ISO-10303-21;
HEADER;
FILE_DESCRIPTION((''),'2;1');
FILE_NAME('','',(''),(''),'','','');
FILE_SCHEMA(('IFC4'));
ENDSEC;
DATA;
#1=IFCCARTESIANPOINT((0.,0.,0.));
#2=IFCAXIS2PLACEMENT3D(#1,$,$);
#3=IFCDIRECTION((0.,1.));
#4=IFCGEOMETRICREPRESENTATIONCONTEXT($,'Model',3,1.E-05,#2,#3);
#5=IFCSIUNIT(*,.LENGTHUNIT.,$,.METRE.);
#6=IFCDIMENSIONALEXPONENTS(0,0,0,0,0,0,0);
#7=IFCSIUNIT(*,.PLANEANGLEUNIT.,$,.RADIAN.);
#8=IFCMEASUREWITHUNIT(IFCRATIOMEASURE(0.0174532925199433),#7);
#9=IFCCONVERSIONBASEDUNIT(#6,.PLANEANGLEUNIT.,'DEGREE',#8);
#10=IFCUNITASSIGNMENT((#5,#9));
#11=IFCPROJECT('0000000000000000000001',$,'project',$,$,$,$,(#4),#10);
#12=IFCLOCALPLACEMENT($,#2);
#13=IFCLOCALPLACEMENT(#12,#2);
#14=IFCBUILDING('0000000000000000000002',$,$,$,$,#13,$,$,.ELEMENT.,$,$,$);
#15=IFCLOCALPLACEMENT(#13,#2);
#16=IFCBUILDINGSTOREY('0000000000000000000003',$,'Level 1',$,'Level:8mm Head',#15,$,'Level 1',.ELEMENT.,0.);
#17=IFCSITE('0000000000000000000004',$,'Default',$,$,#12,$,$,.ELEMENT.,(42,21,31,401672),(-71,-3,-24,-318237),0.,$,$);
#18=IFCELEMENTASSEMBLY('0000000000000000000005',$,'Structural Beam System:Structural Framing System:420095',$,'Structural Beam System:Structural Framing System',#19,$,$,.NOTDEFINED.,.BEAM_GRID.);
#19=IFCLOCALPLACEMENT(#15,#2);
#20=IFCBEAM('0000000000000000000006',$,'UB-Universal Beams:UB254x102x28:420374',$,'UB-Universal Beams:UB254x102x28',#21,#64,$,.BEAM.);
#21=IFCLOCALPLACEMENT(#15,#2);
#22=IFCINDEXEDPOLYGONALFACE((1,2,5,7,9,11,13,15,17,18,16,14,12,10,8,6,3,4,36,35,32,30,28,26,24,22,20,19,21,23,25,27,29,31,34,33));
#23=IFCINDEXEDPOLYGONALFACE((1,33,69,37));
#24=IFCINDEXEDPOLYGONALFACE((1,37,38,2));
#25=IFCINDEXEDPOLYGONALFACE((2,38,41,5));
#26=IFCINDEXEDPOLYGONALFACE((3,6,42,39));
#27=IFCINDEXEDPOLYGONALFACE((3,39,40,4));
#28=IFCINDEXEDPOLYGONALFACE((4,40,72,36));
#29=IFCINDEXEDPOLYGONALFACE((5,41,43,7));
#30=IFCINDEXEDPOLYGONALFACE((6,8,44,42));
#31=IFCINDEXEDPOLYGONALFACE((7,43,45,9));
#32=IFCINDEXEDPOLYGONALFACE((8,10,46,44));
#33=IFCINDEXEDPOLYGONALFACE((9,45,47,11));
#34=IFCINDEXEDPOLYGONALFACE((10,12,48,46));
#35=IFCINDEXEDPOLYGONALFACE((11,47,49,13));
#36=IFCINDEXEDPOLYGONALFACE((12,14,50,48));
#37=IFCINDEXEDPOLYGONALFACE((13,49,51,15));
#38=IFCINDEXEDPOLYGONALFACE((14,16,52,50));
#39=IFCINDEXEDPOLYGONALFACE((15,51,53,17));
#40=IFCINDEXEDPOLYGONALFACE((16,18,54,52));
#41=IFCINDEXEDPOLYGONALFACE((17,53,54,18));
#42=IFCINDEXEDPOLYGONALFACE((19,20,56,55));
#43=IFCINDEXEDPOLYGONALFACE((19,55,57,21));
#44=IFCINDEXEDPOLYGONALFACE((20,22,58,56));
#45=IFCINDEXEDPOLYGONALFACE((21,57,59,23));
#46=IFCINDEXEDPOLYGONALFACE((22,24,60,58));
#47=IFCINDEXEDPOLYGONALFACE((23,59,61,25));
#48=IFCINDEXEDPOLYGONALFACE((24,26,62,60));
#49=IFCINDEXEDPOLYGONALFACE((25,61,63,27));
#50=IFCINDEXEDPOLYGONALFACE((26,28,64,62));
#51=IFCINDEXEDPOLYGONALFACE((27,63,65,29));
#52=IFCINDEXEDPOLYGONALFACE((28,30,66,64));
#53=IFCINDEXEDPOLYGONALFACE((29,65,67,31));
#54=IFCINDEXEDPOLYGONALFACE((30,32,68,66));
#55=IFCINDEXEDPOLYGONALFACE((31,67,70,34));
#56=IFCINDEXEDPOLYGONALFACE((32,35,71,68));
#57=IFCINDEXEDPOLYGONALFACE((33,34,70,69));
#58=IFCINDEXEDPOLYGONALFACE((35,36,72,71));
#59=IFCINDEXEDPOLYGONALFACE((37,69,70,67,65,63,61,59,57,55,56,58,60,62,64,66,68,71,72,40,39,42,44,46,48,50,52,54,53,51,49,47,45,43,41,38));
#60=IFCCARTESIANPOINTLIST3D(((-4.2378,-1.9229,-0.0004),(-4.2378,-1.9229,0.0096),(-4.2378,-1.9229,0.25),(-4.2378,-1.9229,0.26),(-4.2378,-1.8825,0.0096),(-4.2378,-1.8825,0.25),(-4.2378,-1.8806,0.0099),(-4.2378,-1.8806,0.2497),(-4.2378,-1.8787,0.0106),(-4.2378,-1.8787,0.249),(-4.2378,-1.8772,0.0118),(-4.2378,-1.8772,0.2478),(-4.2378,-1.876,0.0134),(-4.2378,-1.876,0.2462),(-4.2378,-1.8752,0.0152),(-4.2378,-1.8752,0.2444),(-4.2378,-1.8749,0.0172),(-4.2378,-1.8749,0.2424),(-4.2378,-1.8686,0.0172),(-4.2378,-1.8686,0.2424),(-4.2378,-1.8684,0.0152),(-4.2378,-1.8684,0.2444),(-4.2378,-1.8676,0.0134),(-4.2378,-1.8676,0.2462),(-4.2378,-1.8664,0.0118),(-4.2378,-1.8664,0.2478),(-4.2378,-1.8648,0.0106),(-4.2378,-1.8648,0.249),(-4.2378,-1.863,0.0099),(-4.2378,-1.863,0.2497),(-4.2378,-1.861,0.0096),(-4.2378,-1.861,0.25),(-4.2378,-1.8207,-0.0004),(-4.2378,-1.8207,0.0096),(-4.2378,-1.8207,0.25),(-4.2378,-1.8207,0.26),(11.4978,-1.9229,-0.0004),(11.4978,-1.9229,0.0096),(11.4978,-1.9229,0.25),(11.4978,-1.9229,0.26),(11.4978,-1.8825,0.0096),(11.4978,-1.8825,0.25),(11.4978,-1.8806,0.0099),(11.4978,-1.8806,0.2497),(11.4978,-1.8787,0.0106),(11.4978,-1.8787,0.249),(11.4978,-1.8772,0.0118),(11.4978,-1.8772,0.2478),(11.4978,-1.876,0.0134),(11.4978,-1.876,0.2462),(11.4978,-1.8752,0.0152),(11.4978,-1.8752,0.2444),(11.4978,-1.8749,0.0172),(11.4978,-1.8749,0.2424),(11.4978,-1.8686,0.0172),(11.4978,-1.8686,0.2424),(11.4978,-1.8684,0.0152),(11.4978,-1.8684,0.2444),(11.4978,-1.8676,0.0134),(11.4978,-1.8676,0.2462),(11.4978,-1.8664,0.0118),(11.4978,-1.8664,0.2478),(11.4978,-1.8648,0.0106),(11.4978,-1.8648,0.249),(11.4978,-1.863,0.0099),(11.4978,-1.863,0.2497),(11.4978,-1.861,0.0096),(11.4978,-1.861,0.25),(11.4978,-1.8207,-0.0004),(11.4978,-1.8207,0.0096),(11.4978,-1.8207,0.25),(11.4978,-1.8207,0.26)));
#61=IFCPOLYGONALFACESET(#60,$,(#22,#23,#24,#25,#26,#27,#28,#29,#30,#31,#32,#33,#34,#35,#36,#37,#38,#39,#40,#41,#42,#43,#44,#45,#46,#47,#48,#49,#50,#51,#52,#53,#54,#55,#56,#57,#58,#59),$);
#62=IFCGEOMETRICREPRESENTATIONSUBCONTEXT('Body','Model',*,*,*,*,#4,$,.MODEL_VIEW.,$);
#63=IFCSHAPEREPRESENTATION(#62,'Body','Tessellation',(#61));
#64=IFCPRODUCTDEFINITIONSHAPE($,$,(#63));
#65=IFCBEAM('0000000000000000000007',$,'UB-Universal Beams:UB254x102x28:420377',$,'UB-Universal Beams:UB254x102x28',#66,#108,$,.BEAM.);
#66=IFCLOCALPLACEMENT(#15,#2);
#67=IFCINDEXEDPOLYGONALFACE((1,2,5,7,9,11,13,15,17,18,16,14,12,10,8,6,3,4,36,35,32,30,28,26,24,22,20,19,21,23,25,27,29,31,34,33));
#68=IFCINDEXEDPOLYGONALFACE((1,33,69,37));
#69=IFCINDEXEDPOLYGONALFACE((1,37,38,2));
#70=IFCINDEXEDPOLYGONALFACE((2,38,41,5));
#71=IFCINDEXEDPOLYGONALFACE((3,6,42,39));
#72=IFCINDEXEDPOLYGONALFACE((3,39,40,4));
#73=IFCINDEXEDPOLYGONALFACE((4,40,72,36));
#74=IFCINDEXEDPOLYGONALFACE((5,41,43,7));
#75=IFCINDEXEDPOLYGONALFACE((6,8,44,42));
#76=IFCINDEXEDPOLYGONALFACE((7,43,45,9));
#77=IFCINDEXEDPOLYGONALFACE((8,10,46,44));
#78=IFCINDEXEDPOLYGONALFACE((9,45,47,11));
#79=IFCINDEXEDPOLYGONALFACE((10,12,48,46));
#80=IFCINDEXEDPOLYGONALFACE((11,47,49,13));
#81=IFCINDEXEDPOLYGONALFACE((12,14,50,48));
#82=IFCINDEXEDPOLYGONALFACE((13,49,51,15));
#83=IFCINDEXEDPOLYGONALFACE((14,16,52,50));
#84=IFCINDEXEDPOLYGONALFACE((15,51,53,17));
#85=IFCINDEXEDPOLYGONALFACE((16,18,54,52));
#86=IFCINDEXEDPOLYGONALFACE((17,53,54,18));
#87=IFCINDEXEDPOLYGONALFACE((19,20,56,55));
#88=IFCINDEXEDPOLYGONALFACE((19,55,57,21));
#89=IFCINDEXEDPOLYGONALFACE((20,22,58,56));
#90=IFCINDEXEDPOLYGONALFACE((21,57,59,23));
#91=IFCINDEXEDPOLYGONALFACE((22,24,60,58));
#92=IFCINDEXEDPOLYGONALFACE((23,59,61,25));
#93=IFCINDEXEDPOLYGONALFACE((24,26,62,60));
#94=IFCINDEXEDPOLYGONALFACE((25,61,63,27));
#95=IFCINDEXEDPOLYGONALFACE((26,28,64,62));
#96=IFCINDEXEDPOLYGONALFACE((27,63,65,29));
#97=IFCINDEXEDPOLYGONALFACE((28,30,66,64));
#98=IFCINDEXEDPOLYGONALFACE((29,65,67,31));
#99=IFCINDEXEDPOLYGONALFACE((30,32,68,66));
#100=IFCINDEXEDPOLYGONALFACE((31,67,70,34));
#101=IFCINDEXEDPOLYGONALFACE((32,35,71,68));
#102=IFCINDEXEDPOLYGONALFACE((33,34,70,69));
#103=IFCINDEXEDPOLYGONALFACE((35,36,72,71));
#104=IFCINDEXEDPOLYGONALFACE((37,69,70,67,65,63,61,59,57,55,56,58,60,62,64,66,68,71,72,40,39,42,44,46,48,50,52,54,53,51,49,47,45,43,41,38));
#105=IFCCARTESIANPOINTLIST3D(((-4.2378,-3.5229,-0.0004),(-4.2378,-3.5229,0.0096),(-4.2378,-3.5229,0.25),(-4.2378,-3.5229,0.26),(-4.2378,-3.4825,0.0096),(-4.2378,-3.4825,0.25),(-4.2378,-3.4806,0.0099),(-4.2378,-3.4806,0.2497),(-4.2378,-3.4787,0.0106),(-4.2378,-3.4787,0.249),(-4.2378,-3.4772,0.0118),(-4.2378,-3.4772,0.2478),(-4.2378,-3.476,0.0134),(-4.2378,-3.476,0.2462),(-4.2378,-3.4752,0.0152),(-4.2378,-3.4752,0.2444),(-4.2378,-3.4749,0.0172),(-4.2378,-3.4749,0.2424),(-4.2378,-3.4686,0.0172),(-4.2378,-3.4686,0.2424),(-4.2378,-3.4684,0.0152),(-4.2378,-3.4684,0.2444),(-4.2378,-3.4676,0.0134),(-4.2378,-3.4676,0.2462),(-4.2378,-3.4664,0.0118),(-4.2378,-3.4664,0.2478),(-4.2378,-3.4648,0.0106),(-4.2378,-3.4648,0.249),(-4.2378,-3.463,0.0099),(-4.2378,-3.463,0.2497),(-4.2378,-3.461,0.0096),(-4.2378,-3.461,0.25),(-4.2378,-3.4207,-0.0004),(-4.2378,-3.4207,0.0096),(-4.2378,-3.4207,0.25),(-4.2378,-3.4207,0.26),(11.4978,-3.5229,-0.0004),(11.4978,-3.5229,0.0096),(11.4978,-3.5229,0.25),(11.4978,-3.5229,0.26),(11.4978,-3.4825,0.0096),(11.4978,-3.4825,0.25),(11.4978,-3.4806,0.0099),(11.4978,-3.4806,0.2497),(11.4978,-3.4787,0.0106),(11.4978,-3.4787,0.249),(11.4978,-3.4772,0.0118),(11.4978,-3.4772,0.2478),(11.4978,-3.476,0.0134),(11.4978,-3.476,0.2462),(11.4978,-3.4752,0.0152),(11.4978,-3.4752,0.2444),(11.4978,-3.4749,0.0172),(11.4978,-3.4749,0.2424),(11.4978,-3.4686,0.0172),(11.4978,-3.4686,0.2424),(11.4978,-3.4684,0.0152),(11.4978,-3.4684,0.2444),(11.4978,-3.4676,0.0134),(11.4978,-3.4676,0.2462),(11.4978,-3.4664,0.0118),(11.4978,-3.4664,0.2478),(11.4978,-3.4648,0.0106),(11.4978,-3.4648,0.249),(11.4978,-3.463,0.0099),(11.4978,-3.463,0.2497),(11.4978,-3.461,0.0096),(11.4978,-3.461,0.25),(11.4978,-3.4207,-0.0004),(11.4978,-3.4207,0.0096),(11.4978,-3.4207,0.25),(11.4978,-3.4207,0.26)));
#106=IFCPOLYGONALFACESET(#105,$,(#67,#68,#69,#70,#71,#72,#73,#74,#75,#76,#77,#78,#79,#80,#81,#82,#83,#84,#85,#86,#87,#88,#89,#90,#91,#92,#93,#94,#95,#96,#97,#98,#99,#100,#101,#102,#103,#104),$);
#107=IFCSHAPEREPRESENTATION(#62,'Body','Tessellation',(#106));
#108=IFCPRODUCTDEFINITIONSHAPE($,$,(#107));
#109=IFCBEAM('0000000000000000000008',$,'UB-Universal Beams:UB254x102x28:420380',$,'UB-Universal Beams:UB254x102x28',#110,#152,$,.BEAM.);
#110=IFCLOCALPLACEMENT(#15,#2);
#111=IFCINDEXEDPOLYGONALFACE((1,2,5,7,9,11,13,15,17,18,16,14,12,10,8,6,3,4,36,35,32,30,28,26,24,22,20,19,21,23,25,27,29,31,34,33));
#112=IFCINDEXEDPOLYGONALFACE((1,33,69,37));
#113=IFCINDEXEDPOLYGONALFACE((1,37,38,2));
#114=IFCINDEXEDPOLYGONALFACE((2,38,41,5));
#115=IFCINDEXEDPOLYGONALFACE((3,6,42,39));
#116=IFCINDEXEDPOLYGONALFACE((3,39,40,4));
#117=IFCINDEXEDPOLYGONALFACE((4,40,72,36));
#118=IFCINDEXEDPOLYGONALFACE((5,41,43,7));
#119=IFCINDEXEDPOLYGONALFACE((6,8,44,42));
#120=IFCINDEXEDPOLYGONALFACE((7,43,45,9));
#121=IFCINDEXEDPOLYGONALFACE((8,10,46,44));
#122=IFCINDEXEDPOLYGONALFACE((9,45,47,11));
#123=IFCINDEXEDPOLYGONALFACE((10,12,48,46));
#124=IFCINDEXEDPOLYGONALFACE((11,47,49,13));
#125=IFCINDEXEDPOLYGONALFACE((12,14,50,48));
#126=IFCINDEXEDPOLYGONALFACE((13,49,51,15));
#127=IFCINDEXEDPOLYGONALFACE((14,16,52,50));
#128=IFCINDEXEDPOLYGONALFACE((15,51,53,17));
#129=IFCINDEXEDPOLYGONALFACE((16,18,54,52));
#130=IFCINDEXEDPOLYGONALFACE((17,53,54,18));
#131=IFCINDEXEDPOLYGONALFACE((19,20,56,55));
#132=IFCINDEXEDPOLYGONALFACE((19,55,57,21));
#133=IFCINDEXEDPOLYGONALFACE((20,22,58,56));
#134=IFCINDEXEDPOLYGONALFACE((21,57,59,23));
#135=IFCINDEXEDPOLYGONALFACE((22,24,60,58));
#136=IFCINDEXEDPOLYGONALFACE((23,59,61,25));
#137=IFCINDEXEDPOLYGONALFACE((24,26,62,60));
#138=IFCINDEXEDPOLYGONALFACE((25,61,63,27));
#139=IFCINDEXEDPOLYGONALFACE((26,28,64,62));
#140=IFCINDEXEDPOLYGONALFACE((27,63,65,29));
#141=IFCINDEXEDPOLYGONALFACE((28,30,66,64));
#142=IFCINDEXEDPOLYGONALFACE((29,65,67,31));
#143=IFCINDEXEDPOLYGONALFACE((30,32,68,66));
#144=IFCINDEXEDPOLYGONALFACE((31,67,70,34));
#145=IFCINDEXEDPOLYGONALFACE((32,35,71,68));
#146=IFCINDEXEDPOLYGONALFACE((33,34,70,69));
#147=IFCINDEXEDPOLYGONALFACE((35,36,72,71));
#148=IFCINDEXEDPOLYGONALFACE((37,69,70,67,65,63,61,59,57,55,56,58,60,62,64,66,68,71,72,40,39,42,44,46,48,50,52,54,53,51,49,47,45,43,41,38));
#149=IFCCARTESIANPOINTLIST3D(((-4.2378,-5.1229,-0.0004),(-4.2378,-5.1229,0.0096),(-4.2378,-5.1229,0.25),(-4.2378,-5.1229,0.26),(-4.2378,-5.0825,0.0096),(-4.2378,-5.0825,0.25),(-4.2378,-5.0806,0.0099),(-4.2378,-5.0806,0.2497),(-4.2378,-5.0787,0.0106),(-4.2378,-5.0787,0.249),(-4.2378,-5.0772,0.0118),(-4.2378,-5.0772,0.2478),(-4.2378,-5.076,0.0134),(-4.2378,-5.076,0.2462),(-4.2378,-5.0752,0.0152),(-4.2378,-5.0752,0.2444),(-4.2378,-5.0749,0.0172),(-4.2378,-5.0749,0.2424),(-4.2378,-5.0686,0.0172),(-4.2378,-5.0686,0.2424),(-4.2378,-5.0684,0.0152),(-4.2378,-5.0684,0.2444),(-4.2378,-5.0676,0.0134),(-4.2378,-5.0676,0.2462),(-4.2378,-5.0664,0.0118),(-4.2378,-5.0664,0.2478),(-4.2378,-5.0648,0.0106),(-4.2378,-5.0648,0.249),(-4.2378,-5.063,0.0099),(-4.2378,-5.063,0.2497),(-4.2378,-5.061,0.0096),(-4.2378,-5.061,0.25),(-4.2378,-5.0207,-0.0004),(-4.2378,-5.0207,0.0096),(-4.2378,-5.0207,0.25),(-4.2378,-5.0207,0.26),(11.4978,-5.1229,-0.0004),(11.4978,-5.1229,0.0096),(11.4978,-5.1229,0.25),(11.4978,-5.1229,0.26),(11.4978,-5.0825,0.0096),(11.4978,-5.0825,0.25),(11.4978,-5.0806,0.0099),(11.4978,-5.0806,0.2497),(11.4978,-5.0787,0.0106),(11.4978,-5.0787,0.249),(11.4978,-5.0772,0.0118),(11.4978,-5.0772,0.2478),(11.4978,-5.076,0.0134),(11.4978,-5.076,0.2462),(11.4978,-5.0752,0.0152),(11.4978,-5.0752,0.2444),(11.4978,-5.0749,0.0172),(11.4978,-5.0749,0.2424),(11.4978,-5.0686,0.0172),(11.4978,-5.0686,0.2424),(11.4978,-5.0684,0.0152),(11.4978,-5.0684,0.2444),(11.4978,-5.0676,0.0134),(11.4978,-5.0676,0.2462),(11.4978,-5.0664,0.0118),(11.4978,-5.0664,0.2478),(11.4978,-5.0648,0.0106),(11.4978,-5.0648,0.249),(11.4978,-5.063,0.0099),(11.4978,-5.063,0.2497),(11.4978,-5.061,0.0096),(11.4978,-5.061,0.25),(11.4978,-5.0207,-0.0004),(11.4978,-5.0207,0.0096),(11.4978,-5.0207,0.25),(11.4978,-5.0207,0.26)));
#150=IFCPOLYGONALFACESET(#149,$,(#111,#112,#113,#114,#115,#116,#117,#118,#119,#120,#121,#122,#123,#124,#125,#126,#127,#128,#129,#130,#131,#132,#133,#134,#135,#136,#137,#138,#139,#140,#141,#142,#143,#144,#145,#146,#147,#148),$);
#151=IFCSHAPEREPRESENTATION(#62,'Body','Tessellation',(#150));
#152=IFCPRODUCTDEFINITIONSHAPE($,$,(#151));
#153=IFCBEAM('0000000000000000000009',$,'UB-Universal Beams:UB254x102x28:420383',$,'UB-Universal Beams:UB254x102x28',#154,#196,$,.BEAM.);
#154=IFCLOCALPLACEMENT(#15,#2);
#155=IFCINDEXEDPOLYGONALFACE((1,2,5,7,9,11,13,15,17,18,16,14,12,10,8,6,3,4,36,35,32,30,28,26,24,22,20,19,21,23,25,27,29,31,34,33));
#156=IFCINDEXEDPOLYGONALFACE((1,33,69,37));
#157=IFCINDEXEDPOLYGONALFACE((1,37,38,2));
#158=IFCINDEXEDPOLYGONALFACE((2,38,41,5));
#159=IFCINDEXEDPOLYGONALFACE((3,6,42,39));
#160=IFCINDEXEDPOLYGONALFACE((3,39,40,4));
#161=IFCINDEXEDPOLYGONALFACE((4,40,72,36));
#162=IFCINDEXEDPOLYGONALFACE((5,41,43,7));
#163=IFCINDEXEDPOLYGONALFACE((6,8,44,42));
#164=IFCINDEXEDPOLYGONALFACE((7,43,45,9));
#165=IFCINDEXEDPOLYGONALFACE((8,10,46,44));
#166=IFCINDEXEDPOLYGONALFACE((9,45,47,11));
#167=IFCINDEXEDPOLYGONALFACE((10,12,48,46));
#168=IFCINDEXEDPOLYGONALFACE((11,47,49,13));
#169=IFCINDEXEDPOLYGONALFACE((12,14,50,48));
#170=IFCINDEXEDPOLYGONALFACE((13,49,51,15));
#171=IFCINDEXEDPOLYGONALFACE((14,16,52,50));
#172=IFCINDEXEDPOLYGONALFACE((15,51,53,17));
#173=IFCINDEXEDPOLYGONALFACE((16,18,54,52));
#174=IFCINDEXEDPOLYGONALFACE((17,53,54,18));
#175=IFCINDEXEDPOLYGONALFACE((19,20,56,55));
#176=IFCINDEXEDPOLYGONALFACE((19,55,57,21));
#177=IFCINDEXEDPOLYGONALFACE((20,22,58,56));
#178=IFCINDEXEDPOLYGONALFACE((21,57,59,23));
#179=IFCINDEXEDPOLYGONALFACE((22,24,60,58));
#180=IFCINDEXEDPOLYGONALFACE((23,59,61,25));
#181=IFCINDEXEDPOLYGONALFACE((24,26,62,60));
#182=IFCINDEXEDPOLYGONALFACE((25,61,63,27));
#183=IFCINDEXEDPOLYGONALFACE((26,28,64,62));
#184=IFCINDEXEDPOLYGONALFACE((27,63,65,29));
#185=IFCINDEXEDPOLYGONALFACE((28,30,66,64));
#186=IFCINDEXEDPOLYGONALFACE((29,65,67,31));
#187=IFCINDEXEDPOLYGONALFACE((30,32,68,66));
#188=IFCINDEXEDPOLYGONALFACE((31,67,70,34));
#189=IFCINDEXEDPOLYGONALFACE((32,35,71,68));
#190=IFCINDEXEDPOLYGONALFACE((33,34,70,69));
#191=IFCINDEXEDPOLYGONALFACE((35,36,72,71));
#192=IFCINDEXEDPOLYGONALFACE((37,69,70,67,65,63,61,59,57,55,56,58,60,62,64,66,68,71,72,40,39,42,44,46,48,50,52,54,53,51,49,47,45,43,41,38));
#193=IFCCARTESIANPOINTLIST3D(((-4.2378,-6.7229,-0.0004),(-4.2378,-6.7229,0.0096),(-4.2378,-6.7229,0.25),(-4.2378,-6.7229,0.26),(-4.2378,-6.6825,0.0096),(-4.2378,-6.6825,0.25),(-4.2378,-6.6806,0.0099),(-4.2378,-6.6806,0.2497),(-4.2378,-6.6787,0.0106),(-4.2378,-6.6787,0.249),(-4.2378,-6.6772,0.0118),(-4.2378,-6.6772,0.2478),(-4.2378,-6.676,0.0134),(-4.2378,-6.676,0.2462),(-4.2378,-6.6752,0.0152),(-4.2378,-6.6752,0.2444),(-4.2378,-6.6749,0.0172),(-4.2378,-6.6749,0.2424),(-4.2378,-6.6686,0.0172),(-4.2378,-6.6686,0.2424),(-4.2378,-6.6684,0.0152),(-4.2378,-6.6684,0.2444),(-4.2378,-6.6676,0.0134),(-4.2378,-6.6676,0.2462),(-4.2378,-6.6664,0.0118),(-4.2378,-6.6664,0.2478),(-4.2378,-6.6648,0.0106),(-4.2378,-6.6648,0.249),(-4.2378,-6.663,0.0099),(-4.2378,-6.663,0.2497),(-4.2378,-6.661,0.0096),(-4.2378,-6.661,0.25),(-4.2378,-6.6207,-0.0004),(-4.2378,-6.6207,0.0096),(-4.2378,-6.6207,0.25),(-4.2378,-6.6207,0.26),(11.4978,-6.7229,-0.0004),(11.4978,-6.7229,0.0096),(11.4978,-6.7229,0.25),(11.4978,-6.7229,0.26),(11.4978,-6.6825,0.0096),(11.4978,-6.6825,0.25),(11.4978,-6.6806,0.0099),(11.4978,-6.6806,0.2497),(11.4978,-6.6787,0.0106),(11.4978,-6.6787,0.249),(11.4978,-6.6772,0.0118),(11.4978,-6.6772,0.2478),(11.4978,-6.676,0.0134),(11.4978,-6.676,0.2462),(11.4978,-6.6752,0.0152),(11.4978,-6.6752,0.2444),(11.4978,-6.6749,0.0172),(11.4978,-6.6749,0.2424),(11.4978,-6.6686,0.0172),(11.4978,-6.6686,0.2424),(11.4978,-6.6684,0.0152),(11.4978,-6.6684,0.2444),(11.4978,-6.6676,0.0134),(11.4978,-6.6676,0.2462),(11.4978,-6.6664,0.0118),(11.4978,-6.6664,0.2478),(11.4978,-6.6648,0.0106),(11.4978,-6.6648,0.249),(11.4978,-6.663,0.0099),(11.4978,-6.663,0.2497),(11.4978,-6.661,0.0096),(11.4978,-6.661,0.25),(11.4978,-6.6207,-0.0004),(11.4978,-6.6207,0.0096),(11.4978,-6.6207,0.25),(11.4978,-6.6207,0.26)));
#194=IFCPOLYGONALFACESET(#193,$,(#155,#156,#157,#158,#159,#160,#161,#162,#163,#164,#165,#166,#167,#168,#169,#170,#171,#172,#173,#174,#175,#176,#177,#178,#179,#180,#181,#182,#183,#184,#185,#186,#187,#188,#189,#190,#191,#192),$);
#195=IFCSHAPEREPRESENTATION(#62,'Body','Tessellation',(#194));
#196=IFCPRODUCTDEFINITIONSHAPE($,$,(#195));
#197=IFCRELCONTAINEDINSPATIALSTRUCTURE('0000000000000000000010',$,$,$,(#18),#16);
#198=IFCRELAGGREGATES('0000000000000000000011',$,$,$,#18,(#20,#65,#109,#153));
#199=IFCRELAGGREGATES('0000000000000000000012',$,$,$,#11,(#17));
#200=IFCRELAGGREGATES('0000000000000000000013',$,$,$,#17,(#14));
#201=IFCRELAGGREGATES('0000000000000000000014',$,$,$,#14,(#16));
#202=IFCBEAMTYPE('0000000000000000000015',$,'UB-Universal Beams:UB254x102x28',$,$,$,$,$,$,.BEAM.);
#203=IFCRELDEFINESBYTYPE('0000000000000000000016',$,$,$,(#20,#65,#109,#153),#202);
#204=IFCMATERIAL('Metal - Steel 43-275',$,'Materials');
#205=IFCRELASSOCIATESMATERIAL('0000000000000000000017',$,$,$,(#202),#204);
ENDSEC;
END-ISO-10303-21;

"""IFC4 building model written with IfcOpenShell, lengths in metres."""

from ifc_helpers import new_model, entity, si_unit, converted_unit, direction, frame, frame_2d, origin, place, context, subcontext, project, spatial, i_section, extrude, source, transform, mapped, material, material_profile, profile_set, type_object, type_shapes, element, aggregate, save


model = new_model("IFC4")

# Units and contexts
model_context = context("Model", 3, precision=1e-05, world=origin(), true_north=direction((0.0, 1.0)))
body_context = subcontext(model_context, "Body", "Model", "MODEL_VIEW")
ifc_project = project(units=[si_unit("LENGTHUNIT", "METRE"), converted_unit("PLANEANGLEUNIT", "DEGREE", entity("IfcRatioMeasure", 0.0174532925199433), si_unit("PLANEANGLEUNIT", "RADIAN"), dimensions=[0, 0, 0, 0, 0, 0, 0])], contexts=[model_context])

# Site, building, storey
site_placement = place(None, origin())
site = spatial("IfcSite", under=ifc_project, at=site_placement, Name="Default", CompositionType="ELEMENT", RefLatitude=(42, 21, 31, 401672), RefLongitude=(-71, -3, -24, -318237), RefElevation=0.0)
building_placement = place(site_placement, origin())
building = spatial("IfcBuilding", under=site, at=building_placement, CompositionType="ELEMENT")
storey_placement = place(building_placement, origin())
storey = spatial("IfcBuildingStorey", under=building, at=storey_placement, Name="Level 1", ObjectType="Level:8mm Head", LongName="Level 1", CompositionType="ELEMENT", Elevation=0.0)

# Shared definitions
ifc_material_1 = material(Name="Metal - Steel 43-275", Category="Materials")

# Element assembly, beams
assembly_placement = place(storey_placement, origin())
assembly = element("IfcElementAssembly", 1, at=assembly_placement, inside=storey, Name="Structural Beam System:Structural Framing System:420095", ObjectType="Structural Beam System:Structural Framing System", AssemblyPlace="NOTDEFINED", PredefinedType="BEAM_GRID")
ifc_material_profile_1 = material_profile(ifc_material_1, i_section(OverallWidth=0.1022, OverallDepth=0.2604, WebThickness=0.0063, FlangeThickness=0.01, FilletRadius=0.0076, at=frame_2d((0.0, 0.0), x_axis=(0.0, 1.0))), Name="UB254x102x28")
ifc_profile_set_1 = profile_set([ifc_material_profile_1], Name="UB254x102x28")
beam_type_1 = type_object("IfcBeamType", Name="UB-Universal Beams:UB254x102x28", PredefinedType="BEAM", material=ifc_profile_set_1)
shared_shape_1 = source(origin(), body_context, "Body", "SweptSolid", [
    extrude(i_section(OverallWidth=0.1022, OverallDepth=0.2604, WebThickness=0.0063, FlangeThickness=0.01, FilletRadius=0.0076, at=frame_2d((0.0, 0.0), x_axis=(0.0, 1.0))), frame((-7.8373, 0.0, 0.0), z_axis=(1.0, 0.0, 0.0), x_axis=(0.0, 0.0, -1.0)), (0.0, 0.0, 1.0), 15.7356),
])
type_shapes(beam_type_1, [shared_shape_1])
beam_1_placement = place(assembly_placement, frame((3.5995, -1.8718, 0.1298)))
beam_1 = element("IfcBeam", 2, at=beam_1_placement, type_object=beam_type_1, Name="UB-Universal Beams:UB254x102x28:420374", ObjectType="UB-Universal Beams:UB254x102x28", PredefinedType="BEAM", context=body_context, shape_type="MappedRepresentation", body=[
    mapped(shared_shape_1, transform((0.0, 0.0, 0.0), scale=1.0)),
])
beam_2_placement = place(assembly_placement, frame((3.5995, -3.4718, 0.1298)))
beam_2 = element("IfcBeam", 3, at=beam_2_placement, type_object=beam_type_1, Name="UB-Universal Beams:UB254x102x28:420377", ObjectType="UB-Universal Beams:UB254x102x28", PredefinedType="BEAM", context=body_context, shape_type="MappedRepresentation", body=[
    mapped(shared_shape_1, transform((0.0, 0.0, 0.0), scale=1.0)),
])
beam_3_placement = place(assembly_placement, frame((3.5995, -5.0718, 0.1298)))
beam_3 = element("IfcBeam", 4, at=beam_3_placement, type_object=beam_type_1, Name="UB-Universal Beams:UB254x102x28:420380", ObjectType="UB-Universal Beams:UB254x102x28", PredefinedType="BEAM", context=body_context, shape_type="MappedRepresentation", body=[
    mapped(shared_shape_1, transform((0.0, 0.0, 0.0), scale=1.0)),
])
beam_4_placement = place(assembly_placement, frame((3.5995, -6.6718, 0.1298)))
beam_4 = element("IfcBeam", 5, at=beam_4_placement, type_object=beam_type_1, Name="UB-Universal Beams:UB254x102x28:420383", ObjectType="UB-Universal Beams:UB254x102x28", PredefinedType="BEAM", context=body_context, shape_type="MappedRepresentation", body=[
    mapped(shared_shape_1, transform((0.0, 0.0, 0.0), scale=1.0)),
])
aggregate(assembly, [beam_1, beam_2, beam_3, beam_4])

save(model, "model.ifc")
